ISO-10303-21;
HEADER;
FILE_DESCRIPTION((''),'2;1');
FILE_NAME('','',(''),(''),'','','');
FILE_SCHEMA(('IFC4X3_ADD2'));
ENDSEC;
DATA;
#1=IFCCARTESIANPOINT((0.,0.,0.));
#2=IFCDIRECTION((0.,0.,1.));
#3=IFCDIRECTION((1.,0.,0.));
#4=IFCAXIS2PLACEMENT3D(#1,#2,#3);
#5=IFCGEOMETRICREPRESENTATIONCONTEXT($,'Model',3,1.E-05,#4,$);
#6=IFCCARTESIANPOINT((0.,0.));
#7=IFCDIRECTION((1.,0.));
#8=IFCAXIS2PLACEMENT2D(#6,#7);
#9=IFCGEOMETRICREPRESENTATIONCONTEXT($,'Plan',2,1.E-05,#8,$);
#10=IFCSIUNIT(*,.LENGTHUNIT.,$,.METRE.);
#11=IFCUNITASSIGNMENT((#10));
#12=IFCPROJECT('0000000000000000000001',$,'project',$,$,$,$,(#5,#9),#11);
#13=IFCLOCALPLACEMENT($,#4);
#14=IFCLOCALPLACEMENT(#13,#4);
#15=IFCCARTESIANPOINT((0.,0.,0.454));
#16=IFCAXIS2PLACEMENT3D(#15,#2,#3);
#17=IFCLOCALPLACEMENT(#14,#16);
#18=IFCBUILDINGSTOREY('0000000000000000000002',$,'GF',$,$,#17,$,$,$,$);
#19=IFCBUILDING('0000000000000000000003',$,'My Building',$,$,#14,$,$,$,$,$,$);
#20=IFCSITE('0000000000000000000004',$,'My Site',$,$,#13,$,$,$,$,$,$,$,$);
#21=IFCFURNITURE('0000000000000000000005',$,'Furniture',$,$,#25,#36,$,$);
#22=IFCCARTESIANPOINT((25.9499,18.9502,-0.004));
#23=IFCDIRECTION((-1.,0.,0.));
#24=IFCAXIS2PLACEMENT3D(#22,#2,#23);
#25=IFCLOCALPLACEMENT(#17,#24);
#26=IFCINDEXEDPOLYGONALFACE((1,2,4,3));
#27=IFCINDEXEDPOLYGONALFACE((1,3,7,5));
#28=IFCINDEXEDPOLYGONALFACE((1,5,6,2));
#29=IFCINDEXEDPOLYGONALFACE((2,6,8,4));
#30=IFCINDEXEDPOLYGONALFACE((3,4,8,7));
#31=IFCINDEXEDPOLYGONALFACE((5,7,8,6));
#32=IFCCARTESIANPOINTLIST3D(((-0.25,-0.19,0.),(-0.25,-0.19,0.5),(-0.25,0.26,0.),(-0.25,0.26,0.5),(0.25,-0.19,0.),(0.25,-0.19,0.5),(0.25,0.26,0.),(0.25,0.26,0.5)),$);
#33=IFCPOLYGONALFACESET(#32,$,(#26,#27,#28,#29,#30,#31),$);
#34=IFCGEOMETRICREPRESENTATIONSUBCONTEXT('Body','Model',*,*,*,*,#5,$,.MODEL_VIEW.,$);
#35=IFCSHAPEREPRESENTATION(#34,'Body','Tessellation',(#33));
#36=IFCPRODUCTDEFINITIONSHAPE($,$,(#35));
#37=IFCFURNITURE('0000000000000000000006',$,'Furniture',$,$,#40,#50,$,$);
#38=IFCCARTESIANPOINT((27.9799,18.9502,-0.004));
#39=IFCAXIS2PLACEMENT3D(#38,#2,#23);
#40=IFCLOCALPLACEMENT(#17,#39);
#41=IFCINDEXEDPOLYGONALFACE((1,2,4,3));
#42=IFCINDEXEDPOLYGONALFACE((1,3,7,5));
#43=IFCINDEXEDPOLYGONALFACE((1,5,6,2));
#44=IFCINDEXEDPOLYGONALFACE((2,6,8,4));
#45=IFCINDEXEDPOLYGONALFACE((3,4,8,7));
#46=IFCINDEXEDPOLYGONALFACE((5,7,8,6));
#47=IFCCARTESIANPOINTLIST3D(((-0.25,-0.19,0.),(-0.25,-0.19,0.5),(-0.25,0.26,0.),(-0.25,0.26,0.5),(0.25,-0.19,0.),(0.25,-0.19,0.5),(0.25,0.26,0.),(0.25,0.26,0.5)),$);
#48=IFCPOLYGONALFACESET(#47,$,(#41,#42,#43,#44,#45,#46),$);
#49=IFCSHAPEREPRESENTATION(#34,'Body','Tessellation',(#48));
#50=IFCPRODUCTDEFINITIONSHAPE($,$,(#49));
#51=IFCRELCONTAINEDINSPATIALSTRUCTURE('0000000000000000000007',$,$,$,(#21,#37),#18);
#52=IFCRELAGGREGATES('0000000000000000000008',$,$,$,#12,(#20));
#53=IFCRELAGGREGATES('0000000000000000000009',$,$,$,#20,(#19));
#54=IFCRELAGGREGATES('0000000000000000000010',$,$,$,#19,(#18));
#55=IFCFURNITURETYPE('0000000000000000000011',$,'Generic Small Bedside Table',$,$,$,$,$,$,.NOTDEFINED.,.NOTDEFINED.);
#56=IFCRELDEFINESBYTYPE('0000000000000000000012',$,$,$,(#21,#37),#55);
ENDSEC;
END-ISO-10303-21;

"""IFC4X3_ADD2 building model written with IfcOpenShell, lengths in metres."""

from ifc_helpers import new_model, entity, si_unit, frame, origin_with_axes, origin_2d_with_axis, place, context, subcontext, project, spatial, line, indexed_curve, outline, extrude, shape, source, transform, mapped, type_object, type_shapes, element, save


model = new_model("IFC4X3_ADD2")

# Units and contexts
model_context = context("Model", 3, precision=1e-05, world=origin_with_axes())
plan_context = context("Plan", 2, precision=1e-05, world=origin_2d_with_axis())
body_context_1 = subcontext(model_context, "Body", "Model", "MODEL_VIEW")
body_context_2 = subcontext(plan_context, "Body", "Plan", "PLAN_VIEW")
ifc_project = project(units=[si_unit("LENGTHUNIT", "METRE")], contexts=[model_context, plan_context])

# Site, building, storey
site_placement = place(None, origin_with_axes())
site = spatial("IfcSite", under=ifc_project, at=site_placement, Name="My Site")
building_placement = place(site_placement, origin_with_axes())
building = spatial("IfcBuilding", under=site, at=building_placement, Name="My Building")
storey_placement = place(building_placement, frame((0.0, 0.0, 0.454), z_axis=(0.0, 0.0, 1.0), x_axis=(1.0, 0.0, 0.0)))
storey = spatial("IfcBuildingStorey", under=building, at=storey_placement, Name="GF")

# Furniture
furniture_type_1 = type_object("IfcFurnitureType", Name="Generic Small Bedside Table", AssemblyPlace="NOTDEFINED", PredefinedType="NOTDEFINED")
shared_shape_1 = source(origin_with_axes(), body_context_1, "Body", "SweptSolid", [
    extrude(outline(indexed_curve([(0.5, 0.45), (0.5, 0.0), (0.0, 0.0), (0.0, 0.45)], segments=[line(4, 1), line(1, 2), line(2, 3), line(3, 4)], self_intersect=False)), frame((-0.25, -0.19, 0.0), z_axis=(0.0, 0.0, 1.0), x_axis=(1.0, 0.0, 0.0)), (0.0, 0.0, 1.0), 0.5),
])
shared_shape_2 = source(origin_with_axes(), body_context_2, "Body", "Annotation2D", [
    entity("IfcGeometricCurveSet", [entity("IfcIndexedPolyCurve", entity("IfcCartesianPointList2D", [[-0.25, -0.19], [0.25, -0.19], [0.25, 0.26], [-0.25, 0.26]]), [entity("IfcLineIndex", [1, 2]), entity("IfcLineIndex", [2, 3]), entity("IfcLineIndex", [3, 4]), entity("IfcLineIndex", [4, 1])])]),
])
type_shapes(furniture_type_1, [shared_shape_1, shared_shape_2])
for number, where, z_axis, x_axis, name in (
    (1, (25.9499, 18.9502, -0.004), (0.0, 0.0, 1.0), (-1.0, 0.0, 0.0), "Furniture"),
    (2, (27.9799, 18.9502, -0.004), (0.0, 0.0, 1.0), (-1.0, 0.0, 0.0), "Furniture"),
):
    element("IfcFurniture", number, at=place(storey_placement, frame(where, z_axis=z_axis, x_axis=x_axis)), inside=storey, type_object=furniture_type_1, Name=name, shapes=[
        shape(body_context_1, "Body", "MappedRepresentation", [mapped(shared_shape_1, transform((0.0, 0.0, 0.0), x_axis=(1.0, 0.0, 0.0), y_axis=(0.0, 1.0, 0.0), z_axis=(0.0, 0.0, 1.0), scale=1.0))]),
        shape(body_context_2, "Body", "MappedRepresentation", [mapped(shared_shape_2, transform((0.0, 0.0, 0.0), x_axis=(1.0, 0.0, 0.0), y_axis=(0.0, 1.0, 0.0), z_axis=(0.0, 0.0, 1.0), scale=1.0))]),
    ])

save(model, "model.ifc")
